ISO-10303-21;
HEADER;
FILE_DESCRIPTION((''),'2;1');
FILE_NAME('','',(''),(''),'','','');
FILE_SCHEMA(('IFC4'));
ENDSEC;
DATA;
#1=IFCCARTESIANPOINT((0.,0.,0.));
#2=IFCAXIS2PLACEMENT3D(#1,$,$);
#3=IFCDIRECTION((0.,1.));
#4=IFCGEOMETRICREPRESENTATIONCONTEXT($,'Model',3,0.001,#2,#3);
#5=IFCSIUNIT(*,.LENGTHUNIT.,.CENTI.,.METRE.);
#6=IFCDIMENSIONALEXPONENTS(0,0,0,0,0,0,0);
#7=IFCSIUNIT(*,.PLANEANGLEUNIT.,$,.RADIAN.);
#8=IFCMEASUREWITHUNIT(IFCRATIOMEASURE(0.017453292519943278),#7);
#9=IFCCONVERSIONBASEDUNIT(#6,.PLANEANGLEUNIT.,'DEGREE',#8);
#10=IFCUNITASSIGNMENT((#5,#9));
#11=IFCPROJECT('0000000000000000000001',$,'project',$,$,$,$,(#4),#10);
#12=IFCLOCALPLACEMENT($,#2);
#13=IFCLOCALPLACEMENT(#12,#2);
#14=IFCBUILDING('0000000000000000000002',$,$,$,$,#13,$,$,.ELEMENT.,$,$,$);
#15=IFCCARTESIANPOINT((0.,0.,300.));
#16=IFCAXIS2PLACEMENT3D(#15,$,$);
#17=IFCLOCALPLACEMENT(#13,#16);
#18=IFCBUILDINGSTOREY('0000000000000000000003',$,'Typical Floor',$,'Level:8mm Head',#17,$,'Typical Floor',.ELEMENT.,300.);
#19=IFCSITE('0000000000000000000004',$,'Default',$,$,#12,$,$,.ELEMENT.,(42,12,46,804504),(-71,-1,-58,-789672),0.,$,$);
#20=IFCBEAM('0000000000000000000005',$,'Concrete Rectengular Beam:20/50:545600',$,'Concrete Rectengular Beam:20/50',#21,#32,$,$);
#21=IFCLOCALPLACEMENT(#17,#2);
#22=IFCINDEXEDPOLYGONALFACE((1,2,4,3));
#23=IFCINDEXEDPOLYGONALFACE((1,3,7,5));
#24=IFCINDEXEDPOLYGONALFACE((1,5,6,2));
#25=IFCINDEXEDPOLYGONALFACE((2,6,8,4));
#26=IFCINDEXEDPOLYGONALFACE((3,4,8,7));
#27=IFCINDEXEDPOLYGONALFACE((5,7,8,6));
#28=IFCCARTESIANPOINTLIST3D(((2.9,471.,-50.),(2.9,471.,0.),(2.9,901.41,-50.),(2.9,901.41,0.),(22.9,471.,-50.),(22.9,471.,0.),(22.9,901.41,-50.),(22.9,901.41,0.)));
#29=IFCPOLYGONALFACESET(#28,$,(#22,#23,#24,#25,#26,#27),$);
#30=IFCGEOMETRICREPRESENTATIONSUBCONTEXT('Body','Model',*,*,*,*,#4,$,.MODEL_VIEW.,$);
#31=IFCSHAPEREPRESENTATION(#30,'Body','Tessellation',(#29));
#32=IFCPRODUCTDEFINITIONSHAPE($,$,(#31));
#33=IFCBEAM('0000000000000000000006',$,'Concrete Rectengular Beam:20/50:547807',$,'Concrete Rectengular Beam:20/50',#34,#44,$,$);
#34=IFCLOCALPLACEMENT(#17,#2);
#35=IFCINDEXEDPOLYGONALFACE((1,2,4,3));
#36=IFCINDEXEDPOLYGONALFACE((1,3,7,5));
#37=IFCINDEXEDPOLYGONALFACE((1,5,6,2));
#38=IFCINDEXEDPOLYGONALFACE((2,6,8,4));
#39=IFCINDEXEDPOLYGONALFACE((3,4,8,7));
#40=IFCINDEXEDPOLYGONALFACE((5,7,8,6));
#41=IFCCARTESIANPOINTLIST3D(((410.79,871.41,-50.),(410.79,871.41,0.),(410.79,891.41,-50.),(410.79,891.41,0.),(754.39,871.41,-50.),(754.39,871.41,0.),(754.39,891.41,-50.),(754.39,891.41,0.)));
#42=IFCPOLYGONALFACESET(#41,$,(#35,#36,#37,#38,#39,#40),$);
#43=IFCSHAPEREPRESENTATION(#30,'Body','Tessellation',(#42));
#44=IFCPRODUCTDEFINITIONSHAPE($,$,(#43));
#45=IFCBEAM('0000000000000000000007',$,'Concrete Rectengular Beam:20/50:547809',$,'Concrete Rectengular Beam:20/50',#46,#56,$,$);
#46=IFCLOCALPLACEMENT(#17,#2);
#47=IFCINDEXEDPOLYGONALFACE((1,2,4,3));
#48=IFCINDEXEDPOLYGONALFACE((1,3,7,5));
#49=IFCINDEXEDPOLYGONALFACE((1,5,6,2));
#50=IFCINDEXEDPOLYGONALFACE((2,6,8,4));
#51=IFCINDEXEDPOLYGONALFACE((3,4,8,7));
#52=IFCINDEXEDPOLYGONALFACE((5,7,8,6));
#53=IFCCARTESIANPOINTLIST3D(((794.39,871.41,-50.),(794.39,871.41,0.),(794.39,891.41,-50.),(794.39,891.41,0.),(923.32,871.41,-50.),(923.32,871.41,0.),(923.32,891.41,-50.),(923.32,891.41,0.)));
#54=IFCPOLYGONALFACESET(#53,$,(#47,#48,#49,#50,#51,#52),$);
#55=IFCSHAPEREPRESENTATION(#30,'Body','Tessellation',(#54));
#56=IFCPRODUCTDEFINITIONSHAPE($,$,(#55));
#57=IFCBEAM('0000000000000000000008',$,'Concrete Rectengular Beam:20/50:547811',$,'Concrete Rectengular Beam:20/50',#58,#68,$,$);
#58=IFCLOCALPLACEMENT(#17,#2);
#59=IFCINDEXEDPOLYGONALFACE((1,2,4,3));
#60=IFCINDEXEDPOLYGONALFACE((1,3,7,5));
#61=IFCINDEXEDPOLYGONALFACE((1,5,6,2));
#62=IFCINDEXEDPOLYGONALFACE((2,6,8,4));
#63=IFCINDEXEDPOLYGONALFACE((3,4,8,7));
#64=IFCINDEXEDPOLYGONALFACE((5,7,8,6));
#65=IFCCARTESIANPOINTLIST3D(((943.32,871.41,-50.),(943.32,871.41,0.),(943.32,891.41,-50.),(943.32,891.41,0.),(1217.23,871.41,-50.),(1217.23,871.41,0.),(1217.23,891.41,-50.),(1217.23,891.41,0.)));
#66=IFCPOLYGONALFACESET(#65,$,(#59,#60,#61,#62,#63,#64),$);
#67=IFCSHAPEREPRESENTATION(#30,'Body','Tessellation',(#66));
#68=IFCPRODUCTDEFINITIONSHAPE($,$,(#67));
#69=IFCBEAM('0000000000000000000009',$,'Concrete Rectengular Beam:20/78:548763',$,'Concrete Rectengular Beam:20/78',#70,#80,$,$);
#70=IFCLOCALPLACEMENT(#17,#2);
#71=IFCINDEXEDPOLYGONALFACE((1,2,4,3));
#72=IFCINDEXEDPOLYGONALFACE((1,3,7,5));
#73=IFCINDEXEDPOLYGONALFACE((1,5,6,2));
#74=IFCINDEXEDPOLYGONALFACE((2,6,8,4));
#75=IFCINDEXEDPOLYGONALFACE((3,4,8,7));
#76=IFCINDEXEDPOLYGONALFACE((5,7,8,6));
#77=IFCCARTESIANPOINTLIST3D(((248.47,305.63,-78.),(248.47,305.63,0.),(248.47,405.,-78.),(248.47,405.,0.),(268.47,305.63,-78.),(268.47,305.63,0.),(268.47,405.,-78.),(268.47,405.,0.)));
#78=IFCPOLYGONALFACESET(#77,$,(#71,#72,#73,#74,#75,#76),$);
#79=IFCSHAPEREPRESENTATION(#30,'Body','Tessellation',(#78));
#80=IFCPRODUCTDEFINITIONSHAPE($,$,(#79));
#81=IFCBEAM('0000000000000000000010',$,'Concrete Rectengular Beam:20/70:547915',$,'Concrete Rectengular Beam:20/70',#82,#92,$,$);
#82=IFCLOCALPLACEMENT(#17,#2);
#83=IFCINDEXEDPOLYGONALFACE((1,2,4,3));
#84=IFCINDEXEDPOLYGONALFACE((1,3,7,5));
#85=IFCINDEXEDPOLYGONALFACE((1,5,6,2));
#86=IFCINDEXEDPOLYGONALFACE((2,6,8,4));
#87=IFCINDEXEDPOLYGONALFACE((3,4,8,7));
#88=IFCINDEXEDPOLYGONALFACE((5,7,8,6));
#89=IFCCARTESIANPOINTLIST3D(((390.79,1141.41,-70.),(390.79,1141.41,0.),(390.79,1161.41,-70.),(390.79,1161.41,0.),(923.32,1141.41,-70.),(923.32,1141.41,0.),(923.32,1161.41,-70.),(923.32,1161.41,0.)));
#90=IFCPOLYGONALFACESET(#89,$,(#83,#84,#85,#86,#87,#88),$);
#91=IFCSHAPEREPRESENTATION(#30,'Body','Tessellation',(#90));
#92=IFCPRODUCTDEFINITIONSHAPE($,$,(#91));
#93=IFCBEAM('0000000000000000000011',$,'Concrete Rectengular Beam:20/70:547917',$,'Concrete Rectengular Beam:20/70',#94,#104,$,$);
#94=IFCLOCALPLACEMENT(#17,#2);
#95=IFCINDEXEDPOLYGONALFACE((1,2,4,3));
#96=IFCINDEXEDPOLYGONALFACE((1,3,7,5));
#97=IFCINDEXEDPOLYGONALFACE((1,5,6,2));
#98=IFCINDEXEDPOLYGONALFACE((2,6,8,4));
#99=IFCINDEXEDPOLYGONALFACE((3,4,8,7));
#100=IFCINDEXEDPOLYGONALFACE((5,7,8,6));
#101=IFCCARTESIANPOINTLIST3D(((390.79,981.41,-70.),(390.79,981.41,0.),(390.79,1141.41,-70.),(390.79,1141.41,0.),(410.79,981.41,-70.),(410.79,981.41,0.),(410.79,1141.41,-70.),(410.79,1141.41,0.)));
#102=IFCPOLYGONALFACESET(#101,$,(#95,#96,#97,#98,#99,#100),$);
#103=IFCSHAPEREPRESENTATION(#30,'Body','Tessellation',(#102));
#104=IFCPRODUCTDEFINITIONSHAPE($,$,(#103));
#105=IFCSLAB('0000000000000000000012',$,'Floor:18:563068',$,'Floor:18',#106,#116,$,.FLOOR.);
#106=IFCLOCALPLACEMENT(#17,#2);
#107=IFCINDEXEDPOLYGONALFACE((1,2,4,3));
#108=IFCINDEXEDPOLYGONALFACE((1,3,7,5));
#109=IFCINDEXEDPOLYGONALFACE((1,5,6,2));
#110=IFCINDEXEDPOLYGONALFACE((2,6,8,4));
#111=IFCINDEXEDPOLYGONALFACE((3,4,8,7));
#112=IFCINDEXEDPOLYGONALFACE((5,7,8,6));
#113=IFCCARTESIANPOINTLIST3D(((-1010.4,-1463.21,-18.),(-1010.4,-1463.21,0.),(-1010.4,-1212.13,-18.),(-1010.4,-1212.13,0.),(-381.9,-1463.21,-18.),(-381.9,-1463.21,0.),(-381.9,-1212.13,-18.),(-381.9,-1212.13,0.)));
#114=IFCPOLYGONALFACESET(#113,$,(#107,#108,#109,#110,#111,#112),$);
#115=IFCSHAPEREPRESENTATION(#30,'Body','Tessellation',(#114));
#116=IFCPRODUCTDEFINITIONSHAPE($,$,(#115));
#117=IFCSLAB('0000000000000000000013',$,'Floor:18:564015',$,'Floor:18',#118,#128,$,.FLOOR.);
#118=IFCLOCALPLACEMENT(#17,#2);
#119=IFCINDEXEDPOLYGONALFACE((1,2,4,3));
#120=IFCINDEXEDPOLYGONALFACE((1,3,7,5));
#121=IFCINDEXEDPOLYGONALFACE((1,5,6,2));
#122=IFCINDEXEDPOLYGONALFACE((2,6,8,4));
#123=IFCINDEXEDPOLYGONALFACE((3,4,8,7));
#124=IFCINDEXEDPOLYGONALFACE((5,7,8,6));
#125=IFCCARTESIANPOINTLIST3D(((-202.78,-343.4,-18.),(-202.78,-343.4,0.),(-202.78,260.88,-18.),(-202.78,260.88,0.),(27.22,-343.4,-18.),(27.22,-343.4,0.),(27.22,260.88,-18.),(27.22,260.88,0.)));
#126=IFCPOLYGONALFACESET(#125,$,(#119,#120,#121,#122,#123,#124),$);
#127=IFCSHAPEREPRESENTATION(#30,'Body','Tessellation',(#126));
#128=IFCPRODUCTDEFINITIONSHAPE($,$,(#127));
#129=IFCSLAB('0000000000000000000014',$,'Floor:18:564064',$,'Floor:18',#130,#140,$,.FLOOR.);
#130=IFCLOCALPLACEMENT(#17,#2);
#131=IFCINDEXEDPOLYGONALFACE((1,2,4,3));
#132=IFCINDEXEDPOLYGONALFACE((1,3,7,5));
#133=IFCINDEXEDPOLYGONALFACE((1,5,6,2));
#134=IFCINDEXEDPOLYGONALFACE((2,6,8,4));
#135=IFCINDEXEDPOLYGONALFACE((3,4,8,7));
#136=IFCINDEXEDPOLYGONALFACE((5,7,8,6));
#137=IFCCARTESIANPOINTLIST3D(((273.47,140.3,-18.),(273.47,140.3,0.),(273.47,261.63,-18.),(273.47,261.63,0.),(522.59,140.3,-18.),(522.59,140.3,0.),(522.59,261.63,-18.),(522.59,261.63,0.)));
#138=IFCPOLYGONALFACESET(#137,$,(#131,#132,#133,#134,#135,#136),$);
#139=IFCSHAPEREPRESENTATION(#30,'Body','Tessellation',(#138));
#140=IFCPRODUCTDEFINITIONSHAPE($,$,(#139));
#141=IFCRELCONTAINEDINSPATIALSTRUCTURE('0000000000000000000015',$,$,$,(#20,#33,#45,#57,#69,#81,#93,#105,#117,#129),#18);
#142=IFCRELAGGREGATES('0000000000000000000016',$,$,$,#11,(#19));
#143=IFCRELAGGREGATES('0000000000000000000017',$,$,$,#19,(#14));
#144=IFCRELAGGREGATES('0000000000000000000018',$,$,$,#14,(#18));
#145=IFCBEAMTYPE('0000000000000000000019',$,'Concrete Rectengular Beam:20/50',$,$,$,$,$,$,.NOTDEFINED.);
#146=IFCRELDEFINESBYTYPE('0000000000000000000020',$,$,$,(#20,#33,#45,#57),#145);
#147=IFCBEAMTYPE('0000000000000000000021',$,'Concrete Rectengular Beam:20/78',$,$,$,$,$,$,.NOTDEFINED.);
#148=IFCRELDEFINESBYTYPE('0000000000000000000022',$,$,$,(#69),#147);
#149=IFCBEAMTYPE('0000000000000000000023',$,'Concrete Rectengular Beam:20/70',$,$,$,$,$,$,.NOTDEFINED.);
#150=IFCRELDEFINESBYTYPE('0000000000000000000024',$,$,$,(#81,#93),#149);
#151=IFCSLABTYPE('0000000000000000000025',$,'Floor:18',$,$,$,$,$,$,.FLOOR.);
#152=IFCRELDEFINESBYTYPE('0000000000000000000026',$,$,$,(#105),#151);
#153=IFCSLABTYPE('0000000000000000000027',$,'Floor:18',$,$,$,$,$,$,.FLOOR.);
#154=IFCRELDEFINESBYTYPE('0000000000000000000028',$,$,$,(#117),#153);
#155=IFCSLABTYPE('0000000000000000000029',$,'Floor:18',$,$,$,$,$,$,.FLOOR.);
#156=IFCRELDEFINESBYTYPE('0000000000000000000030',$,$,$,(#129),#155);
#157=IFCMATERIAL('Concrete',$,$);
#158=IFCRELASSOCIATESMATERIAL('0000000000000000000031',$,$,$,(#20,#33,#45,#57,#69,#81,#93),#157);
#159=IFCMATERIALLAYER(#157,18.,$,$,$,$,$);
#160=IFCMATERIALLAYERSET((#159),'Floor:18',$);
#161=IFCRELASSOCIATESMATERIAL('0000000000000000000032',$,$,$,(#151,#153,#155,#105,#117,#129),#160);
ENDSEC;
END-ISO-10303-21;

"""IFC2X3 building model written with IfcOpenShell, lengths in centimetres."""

from ifc_helpers import new_model, entity, si_unit, converted_unit, direction, frame, frame_2d, origin, origin_2d_with_axis, place, context, subcontext, project, spatial, rectangle, extrude, material, layer, layer_set, layer_usage, type_object, element, save


model = new_model("IFC2X3")

# Units and contexts
model_context = context("Model", 3, precision=0.001, world=origin(), true_north=direction((0.0, 1.0)))
body_context = subcontext(model_context, "Body", "Model", "MODEL_VIEW")
ifc_project = project(units=[si_unit("LENGTHUNIT", "METRE", prefix="CENTI"), converted_unit("PLANEANGLEUNIT", "DEGREE", entity("IfcRatioMeasure", 0.017453292519943278), si_unit("PLANEANGLEUNIT", "RADIAN"), dimensions=[0, 0, 0, 0, 0, 0, 0])], contexts=[model_context])

# Site, building, storey
site_placement = place(None, origin())
site = spatial("IfcSite", under=ifc_project, at=site_placement, Name="Default", CompositionType="ELEMENT", RefLatitude=(42, 12, 46, 804504), RefLongitude=(-71, -1, -58, -789672), RefElevation=0.0)
building_placement = place(site_placement, origin())
building = spatial("IfcBuilding", under=site, at=building_placement, CompositionType="ELEMENT")
storey_placement = place(building_placement, frame((0.0, 0.0, 300.0)))
storey = spatial("IfcBuildingStorey", under=building, at=storey_placement, Name="Typical Floor", ObjectType="Level:8mm Head", LongName="Typical Floor", CompositionType="ELEMENT", Elevation=300.0)

# Beams
ifc_material = material(Name="Concrete")
beam_type_1 = type_object("IfcBeamType", Name="Concrete Rectengular Beam:20/50", PredefinedType="NOTDEFINED")
beam_1_placement = place(storey_placement, frame((12.9, 911.41, 0.0), z_axis=(0.0, 0.0, 1.0), x_axis=(0.0, -1.0, 0.0)))
element("IfcBeam", 1, at=beam_1_placement, inside=storey, type_object=beam_type_1, material=ifc_material, Name="Concrete Rectengular Beam:20/50:545600", ObjectType="Concrete Rectengular Beam:20/50", context=body_context, shape_type="SweptSolid", body=[
    extrude(rectangle(XDim=50.0, YDim=20.0, at=origin_2d_with_axis()), frame((10.0, 0.0, -25.0), z_axis=(1.0, 0.0, 0.0), x_axis=(0.0, 0.0, -1.0)), (0.0, 0.0, 1.0), 430.42),
])
beam_2_placement = place(storey_placement, frame((400.79, 881.41, 0.0)))
element("IfcBeam", 2, at=beam_2_placement, inside=storey, type_object=beam_type_1, material=ifc_material, Name="Concrete Rectengular Beam:20/50:547807", ObjectType="Concrete Rectengular Beam:20/50", context=body_context, shape_type="SweptSolid", body=[
    extrude(rectangle(XDim=50.0, YDim=20.0, at=frame_2d((0.0, 0.0), x_axis=(1.0, 0.0))), frame((10.0, 0.0, -25.0), z_axis=(1.0, 0.0, 0.0), x_axis=(0.0, 0.0, -1.0)), (0.0, 0.0, 1.0), 343.61),
])
beam_3_placement = place(storey_placement, frame((774.39, 881.41, 0.0)))
element("IfcBeam", 3, at=beam_3_placement, inside=storey, type_object=beam_type_1, material=ifc_material, Name="Concrete Rectengular Beam:20/50:547809", ObjectType="Concrete Rectengular Beam:20/50", context=body_context, shape_type="SweptSolid", body=[
    extrude(rectangle(XDim=50.0, YDim=20.0, at=frame_2d((0.0, 0.0), x_axis=(1.0, 0.0))), frame((20.0, 0.0, -25.0), z_axis=(1.0, 0.0, 0.0), x_axis=(0.0, 0.0, -1.0)), (0.0, 0.0, 1.0), 128.92),
])
beam_4_placement = place(storey_placement, frame((933.32, 881.41, 0.0)))
element("IfcBeam", 4, at=beam_4_placement, inside=storey, type_object=beam_type_1, material=ifc_material, Name="Concrete Rectengular Beam:20/50:547811", ObjectType="Concrete Rectengular Beam:20/50", context=body_context, shape_type="SweptSolid", body=[
    extrude(rectangle(XDim=50.0, YDim=20.0, at=frame_2d((0.0, 0.0), x_axis=(1.0, 0.0))), frame((10.0, 0.0, -25.0), z_axis=(1.0, 0.0, 0.0), x_axis=(0.0, 0.0, -1.0)), (0.0, 0.0, 1.0), 273.91),
])
beam_type_2 = type_object("IfcBeamType", Name="Concrete Rectengular Beam:20/78", PredefinedType="NOTDEFINED")
beam_5_placement = place(storey_placement, frame((258.47, 415.0, 0.0), z_axis=(0.0, 0.0, 1.0), x_axis=(0.0, -1.0, 0.0)))
element("IfcBeam", 5, at=beam_5_placement, inside=storey, type_object=beam_type_2, material=ifc_material, Name="Concrete Rectengular Beam:20/78:548763", ObjectType="Concrete Rectengular Beam:20/78", context=body_context, shape_type="SweptSolid", body=[
    extrude(rectangle(XDim=78.0, YDim=20.0, at=frame_2d((0.0, 0.0), x_axis=(1.0, 0.0))), frame((10.0, 0.0, -39.0), z_axis=(1.0, 0.0, 0.0), x_axis=(0.0, 0.0, -1.0)), (0.0, 0.0, 1.0), 99.37),
])
beam_type_3 = type_object("IfcBeamType", Name="Concrete Rectengular Beam:20/70", PredefinedType="NOTDEFINED")
beam_6_placement = place(storey_placement, frame((933.32, 1151.41, 0.0), z_axis=(0.0, 0.0, 1.0), x_axis=(-1.0, 0.0, 0.0)))
element("IfcBeam", 6, at=beam_6_placement, inside=storey, type_object=beam_type_3, material=ifc_material, Name="Concrete Rectengular Beam:20/70:547915", ObjectType="Concrete Rectengular Beam:20/70", context=body_context, shape_type="SweptSolid", body=[
    extrude(rectangle(XDim=70.0, YDim=20.0, at=frame_2d((0.0, 0.0), x_axis=(1.0, 0.0))), frame((10.0, 0.0, -35.0), z_axis=(1.0, 0.0, 0.0), x_axis=(0.0, 0.0, -1.0)), (0.0, 0.0, 1.0), 532.53),
])
beam_7_placement = place(storey_placement, frame((400.79, 1151.41, 0.0), z_axis=(0.0, 0.0, 1.0), x_axis=(0.0, -1.0, 0.0)))
element("IfcBeam", 7, at=beam_7_placement, inside=storey, type_object=beam_type_3, material=ifc_material, Name="Concrete Rectengular Beam:20/70:547917", ObjectType="Concrete Rectengular Beam:20/70", context=body_context, shape_type="SweptSolid", body=[
    extrude(rectangle(XDim=70.0, YDim=20.0, at=origin_2d_with_axis()), frame((10.0, 0.0, -35.0), z_axis=(1.0, 0.0, 0.0), x_axis=(0.0, 0.0, -1.0)), (0.0, 0.0, 1.0), 160.0),
])

# Slabs
ifc_layer = layer(ifc_material, 18.0)
ifc_layer_set = layer_set([ifc_layer], Name="Floor:18")
ifc_layer_usage_1 = layer_usage(ifc_layer_set, "AXIS3", "POSITIVE", 0.0)
slab_type_1 = type_object("IfcSlabType", Name="Floor:18", PredefinedType="FLOOR", material=ifc_layer_set)
slab_1_placement = place(storey_placement, origin())
element("IfcSlab", 8, at=slab_1_placement, inside=storey, type_object=slab_type_1, material=ifc_layer_usage_1, Name="Floor:18:563068", ObjectType="Floor:18", PredefinedType="FLOOR", context=body_context, shape_type="SweptSolid", body=[
    extrude(rectangle(XDim=251.08, YDim=628.49, at=origin_2d_with_axis()), frame((-696.15, -1337.67, 0.0), z_axis=(0.0, 0.0, -1.0), x_axis=(0.0, 1.0, 0.0)), (0.0, 0.0, 1.0), 18.0),
])
ifc_layer_usage_2 = layer_usage(ifc_layer_set, "AXIS3", "POSITIVE", 0.0)
slab_type_2 = type_object("IfcSlabType", Name="Floor:18", PredefinedType="FLOOR", material=ifc_layer_set)
slab_2_placement = place(storey_placement, origin())
element("IfcSlab", 9, at=slab_2_placement, inside=storey, type_object=slab_type_2, material=ifc_layer_usage_2, Name="Floor:18:564015", ObjectType="Floor:18", PredefinedType="FLOOR", context=body_context, shape_type="SweptSolid", body=[
    extrude(rectangle(XDim=604.28, YDim=230.0, at=frame_2d((0.0, 0.0), x_axis=(1.0, 0.0))), frame((-87.78, -41.26, 0.0), z_axis=(0.0, 0.0, -1.0), x_axis=(0.0, 1.0, 0.0)), (0.0, 0.0, 1.0), 18.0),
])
ifc_layer_usage_3 = layer_usage(ifc_layer_set, "AXIS3", "POSITIVE", 0.0)
slab_type_3 = type_object("IfcSlabType", Name="Floor:18", PredefinedType="FLOOR", material=ifc_layer_set)
slab_3_placement = place(storey_placement, origin())
element("IfcSlab", 10, at=slab_3_placement, inside=storey, type_object=slab_type_3, material=ifc_layer_usage_3, Name="Floor:18:564064", ObjectType="Floor:18", PredefinedType="FLOOR", context=body_context, shape_type="SweptSolid", body=[
    extrude(rectangle(XDim=121.33, YDim=249.12, at=origin_2d_with_axis()), frame((398.03, 200.96, 0.0), z_axis=(0.0, 0.0, -1.0), x_axis=(0.0, 1.0, 0.0)), (0.0, 0.0, 1.0), 18.0),
])

save(model, "model.ifc")
